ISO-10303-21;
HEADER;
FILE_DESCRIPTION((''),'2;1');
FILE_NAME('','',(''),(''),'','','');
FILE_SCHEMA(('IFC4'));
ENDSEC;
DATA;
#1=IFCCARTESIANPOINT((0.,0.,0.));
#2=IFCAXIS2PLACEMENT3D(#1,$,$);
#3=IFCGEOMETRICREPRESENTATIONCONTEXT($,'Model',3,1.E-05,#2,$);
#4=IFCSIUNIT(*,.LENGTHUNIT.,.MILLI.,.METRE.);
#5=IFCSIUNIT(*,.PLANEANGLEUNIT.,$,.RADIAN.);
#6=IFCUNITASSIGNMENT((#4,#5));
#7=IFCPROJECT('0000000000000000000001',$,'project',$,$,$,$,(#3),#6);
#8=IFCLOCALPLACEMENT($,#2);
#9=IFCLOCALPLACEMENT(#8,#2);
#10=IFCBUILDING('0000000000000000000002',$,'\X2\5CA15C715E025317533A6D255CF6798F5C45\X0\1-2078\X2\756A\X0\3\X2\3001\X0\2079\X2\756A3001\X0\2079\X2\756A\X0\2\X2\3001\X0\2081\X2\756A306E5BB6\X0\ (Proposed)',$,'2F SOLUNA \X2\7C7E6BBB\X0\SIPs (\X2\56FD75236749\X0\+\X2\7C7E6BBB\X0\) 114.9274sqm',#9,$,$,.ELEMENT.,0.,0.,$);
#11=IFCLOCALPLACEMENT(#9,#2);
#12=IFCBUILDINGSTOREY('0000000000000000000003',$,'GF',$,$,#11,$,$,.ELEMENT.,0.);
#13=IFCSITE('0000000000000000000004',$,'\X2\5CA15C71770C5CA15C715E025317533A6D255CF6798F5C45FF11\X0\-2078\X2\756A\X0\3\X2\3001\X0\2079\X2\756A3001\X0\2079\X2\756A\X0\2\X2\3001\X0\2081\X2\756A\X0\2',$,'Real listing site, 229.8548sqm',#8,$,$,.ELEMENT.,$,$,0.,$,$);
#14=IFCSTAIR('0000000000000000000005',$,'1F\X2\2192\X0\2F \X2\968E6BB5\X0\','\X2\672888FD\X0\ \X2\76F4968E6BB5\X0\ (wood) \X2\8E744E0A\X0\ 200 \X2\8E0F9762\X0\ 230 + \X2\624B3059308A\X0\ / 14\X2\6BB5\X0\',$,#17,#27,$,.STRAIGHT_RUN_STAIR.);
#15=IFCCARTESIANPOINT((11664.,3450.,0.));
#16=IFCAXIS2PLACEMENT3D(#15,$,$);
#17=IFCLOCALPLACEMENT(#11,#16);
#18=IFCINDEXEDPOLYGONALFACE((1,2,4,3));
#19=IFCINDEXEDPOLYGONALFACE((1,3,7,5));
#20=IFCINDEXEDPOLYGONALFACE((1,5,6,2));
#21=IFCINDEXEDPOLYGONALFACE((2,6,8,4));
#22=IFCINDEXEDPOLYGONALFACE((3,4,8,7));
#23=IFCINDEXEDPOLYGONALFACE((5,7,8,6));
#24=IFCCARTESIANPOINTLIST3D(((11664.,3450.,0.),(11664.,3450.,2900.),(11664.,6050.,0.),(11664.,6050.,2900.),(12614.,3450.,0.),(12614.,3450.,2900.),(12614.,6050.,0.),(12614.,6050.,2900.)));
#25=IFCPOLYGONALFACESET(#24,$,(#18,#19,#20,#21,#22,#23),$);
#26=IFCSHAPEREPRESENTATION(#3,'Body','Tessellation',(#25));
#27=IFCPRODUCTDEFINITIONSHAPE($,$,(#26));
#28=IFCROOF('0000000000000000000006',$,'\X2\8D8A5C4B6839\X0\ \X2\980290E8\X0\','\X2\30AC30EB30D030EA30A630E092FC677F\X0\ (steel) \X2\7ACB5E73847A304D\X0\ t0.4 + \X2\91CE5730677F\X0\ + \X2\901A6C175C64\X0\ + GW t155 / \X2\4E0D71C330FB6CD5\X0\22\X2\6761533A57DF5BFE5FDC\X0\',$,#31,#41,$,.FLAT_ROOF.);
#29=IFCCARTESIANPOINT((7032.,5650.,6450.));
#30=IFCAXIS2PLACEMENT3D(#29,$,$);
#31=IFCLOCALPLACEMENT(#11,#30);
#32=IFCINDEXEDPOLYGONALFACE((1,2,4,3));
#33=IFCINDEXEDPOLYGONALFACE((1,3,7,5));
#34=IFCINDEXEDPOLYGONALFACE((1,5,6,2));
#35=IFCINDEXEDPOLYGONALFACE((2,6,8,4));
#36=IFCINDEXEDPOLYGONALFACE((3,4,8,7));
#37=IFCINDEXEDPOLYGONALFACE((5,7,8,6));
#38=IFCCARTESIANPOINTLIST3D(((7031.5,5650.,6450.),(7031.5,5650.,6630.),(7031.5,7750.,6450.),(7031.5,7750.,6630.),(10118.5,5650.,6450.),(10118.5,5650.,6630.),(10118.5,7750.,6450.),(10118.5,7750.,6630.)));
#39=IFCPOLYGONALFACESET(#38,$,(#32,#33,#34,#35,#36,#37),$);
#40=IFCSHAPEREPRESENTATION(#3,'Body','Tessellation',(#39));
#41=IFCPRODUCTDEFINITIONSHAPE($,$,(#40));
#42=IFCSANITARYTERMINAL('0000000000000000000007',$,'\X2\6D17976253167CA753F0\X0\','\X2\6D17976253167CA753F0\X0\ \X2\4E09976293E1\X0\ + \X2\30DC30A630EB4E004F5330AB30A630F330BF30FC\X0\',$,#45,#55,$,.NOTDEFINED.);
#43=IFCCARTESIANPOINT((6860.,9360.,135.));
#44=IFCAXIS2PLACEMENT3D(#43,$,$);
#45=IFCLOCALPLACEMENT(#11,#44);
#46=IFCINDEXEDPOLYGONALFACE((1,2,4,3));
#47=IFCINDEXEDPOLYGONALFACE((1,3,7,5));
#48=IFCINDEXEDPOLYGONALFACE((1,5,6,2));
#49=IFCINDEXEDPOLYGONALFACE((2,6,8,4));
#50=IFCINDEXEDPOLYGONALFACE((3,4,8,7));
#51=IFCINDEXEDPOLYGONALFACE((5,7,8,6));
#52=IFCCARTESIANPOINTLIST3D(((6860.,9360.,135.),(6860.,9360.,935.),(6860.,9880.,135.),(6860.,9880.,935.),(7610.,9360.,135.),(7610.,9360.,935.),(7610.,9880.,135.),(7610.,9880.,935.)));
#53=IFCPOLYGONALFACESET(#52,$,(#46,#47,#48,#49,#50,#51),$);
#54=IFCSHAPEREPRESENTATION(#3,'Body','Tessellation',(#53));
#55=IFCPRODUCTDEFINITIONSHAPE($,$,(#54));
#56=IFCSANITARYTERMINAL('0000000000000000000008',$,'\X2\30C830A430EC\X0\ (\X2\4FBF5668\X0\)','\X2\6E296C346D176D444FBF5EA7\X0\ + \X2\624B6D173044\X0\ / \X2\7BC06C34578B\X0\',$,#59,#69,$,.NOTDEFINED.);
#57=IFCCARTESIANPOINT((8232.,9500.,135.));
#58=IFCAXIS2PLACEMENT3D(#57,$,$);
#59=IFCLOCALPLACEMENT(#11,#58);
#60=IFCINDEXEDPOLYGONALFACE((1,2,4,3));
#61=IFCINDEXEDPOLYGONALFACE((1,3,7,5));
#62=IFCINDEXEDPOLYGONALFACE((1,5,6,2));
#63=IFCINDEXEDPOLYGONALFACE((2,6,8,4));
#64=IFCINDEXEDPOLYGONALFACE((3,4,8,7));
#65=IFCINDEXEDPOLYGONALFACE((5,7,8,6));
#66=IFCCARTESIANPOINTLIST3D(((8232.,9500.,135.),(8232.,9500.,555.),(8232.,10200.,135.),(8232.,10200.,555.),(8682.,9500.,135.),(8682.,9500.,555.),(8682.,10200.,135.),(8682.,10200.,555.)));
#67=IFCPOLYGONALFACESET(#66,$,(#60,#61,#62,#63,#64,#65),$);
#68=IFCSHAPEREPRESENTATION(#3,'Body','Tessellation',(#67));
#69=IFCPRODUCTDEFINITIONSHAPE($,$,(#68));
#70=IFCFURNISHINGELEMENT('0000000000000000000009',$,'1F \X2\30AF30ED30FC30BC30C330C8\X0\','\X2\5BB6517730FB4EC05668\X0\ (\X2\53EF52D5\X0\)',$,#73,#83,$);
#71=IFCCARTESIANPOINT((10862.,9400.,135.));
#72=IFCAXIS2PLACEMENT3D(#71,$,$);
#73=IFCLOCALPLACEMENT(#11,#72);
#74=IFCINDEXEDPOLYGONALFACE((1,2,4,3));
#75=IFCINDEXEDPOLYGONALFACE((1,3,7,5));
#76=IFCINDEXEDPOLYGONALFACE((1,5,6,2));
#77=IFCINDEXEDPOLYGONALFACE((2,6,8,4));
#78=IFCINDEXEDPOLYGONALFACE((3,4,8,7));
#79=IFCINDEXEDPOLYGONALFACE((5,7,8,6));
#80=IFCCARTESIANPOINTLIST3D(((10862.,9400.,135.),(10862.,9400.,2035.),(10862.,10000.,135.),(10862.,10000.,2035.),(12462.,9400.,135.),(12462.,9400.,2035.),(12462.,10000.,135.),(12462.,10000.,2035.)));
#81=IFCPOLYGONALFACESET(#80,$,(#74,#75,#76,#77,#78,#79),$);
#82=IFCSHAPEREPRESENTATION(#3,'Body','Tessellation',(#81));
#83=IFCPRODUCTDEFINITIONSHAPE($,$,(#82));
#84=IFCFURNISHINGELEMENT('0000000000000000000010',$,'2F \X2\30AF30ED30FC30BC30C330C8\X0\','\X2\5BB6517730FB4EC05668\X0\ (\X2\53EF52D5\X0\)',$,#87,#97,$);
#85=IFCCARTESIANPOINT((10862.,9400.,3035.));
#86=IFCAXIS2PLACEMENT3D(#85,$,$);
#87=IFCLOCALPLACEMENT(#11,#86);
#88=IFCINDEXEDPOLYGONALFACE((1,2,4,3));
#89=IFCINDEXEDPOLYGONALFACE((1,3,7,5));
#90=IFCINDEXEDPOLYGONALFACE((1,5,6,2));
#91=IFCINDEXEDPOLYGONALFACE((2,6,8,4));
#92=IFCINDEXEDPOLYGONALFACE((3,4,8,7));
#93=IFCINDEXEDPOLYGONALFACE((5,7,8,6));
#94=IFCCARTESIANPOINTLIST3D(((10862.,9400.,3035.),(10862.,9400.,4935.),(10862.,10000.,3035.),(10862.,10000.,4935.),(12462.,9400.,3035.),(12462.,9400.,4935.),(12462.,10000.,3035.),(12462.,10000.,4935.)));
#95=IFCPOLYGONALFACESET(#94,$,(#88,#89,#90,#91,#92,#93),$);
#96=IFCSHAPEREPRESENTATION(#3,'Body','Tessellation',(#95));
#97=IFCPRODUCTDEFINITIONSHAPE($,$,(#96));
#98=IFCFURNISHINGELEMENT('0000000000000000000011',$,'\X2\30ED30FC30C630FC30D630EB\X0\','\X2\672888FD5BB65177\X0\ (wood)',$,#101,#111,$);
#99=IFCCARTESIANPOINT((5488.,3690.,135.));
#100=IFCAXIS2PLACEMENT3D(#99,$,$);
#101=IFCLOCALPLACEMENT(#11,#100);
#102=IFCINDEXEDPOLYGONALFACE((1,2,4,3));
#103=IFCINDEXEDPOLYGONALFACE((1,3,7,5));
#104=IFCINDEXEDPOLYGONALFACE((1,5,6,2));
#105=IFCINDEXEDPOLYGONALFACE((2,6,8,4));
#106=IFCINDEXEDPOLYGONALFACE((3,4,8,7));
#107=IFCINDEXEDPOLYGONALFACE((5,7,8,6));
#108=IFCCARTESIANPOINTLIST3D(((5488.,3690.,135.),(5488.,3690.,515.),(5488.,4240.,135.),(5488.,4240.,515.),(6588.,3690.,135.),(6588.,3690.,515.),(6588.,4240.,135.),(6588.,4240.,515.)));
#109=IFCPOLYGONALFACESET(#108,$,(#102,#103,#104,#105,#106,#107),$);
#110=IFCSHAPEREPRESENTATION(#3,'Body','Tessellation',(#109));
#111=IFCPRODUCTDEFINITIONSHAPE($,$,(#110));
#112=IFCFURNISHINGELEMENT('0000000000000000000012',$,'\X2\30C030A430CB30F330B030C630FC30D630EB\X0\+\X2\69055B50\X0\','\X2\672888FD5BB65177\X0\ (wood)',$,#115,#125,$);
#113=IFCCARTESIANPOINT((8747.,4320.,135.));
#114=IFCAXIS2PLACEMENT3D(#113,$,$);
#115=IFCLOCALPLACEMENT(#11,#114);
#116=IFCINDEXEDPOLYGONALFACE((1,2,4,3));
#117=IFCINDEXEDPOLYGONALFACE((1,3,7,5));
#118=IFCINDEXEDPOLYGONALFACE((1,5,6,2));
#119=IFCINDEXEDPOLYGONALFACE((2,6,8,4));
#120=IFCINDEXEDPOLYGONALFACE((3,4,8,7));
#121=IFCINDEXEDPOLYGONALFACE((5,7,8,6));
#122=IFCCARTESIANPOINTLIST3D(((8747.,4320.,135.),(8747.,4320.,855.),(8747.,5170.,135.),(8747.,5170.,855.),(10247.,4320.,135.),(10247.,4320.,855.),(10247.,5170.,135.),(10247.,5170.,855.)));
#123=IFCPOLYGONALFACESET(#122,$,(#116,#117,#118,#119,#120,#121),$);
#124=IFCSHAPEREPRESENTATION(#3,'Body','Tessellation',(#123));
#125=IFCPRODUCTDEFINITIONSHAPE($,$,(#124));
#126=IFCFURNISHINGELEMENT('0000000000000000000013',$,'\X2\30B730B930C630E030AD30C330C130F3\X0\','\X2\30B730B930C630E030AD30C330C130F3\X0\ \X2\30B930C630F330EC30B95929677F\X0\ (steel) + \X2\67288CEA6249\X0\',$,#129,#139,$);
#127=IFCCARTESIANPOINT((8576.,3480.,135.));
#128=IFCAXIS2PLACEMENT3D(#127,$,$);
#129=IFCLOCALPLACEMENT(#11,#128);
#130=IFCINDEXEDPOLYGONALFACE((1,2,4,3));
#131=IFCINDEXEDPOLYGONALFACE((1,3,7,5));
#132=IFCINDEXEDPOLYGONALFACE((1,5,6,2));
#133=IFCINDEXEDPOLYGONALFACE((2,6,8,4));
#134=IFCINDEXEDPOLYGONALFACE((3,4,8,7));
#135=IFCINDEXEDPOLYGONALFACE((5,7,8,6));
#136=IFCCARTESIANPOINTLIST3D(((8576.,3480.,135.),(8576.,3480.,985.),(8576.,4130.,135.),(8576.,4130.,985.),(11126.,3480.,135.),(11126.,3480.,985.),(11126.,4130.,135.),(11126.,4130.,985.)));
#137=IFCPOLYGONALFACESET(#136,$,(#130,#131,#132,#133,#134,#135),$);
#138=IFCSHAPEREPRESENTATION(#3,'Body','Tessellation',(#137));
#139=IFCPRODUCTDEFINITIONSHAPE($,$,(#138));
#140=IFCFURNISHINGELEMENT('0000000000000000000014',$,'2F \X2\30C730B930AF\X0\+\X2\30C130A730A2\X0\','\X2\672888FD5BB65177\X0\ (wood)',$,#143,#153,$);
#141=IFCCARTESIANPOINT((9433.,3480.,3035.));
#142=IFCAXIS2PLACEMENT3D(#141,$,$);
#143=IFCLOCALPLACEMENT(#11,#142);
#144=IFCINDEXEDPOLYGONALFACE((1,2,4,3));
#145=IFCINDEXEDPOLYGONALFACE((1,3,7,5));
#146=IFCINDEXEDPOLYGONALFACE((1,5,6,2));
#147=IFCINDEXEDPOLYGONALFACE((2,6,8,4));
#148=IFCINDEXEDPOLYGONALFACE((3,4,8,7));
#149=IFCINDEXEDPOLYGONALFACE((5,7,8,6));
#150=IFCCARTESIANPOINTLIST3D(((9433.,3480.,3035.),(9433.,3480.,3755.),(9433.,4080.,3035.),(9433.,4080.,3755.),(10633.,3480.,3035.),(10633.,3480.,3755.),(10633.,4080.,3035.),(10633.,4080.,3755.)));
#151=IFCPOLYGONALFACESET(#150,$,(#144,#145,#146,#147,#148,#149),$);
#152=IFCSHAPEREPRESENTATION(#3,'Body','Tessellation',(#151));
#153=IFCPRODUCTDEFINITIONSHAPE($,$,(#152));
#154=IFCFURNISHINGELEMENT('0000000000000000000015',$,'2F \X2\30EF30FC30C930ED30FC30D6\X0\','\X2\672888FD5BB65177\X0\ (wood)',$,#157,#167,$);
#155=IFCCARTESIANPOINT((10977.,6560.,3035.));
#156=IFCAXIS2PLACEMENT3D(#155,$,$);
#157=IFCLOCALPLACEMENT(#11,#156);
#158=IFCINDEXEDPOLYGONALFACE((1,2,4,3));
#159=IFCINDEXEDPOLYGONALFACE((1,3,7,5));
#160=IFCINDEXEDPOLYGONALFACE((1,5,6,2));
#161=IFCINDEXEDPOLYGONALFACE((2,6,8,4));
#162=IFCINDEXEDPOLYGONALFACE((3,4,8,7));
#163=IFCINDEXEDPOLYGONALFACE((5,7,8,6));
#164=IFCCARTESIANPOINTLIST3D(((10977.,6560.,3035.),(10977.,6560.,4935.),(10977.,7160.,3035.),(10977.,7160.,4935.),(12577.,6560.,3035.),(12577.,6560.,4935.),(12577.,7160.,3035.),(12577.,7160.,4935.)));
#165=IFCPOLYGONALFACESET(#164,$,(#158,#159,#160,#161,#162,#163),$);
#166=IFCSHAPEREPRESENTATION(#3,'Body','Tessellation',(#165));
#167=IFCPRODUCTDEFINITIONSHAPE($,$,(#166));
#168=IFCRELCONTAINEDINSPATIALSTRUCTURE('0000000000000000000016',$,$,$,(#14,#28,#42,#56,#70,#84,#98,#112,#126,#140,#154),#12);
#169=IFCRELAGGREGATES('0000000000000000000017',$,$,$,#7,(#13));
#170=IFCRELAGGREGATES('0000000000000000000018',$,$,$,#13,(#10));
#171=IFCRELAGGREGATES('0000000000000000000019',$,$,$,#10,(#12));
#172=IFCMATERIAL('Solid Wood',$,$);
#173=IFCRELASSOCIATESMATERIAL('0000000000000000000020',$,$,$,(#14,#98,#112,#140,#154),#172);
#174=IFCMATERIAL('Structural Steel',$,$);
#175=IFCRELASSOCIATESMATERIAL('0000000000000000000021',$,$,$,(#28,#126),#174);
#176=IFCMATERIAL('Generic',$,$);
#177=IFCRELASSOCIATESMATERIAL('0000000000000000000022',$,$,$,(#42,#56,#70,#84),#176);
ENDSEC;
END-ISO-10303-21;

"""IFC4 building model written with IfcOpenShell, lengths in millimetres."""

from ifc_helpers import new_model, si_unit, frame, frame_2d, origin, place, context, project, spatial, rectangle, extrude, material, element, save


model = new_model("IFC4")

# Units and contexts
model_context = context("Model", 3, precision=1e-05, world=origin())
ifc_project = project(units=[si_unit("LENGTHUNIT", "METRE", prefix="MILLI"), si_unit("PLANEANGLEUNIT", "RADIAN")], contexts=[model_context])

# Site, building, storey
site_placement = place(None, origin())
site = spatial("IfcSite", under=ifc_project, at=site_placement, Name="岡山県岡山市北区津島福居１-2078番3、2079番、2079番2、2081番2", ObjectType="Real listing site, 229.8548sqm", CompositionType="ELEMENT", RefElevation=0.0)
building_placement = place(site_placement, origin())
building = spatial("IfcBuilding", under=site, at=building_placement, Name="岡山市北区津島福居1-2078番3、2079番、2079番2、2081番の家 (Proposed)", ObjectType="2F SOLUNA 籾殻SIPs (国産杉+籾殻) 114.9274sqm", CompositionType="ELEMENT", ElevationOfRefHeight=0.0, ElevationOfTerrain=0.0)
storey_placement = place(building_placement, origin())
storey = spatial("IfcBuildingStorey", under=building, at=storey_placement, Name="GF", CompositionType="ELEMENT", Elevation=0.0)

# Shared definitions
ifc_material_1 = material(Name="Solid Wood")

# Stair
stair_placement = place(storey_placement, frame((11664.0, 3450.0, 0.0)))
element("IfcStair", 1, at=stair_placement, inside=storey, material=ifc_material_1, Name="1F→2F 階段", Description="木製 直階段 (wood) 蹴上 200 踏面 230 + 手すり / 14段", PredefinedType="STRAIGHT_RUN_STAIR", context=model_context, shape_type="SweptSolid", body=[
    extrude(rectangle(XDim=950.0, YDim=2600.0, at=frame_2d((475.0, 1300.0))), frame((11664.0, 3450.0, 0.0)), (0.0, 0.0, 1.0), 2900.0),
])

# Roof
ifc_material_2 = material(Name="Structural Steel")
roof_placement = place(storey_placement, frame((7032.0, 5650.0, 6450.0)))
element("IfcRoof", 2, at=roof_placement, inside=storey, material=ifc_material_2, Name="越屋根 頂部", Description="ガルバリウム鋼板 (steel) 立平葺き t0.4 + 野地板 + 通気層 + GW t155 / 不燃・法22条区域対応", PredefinedType="FLAT_ROOF", context=model_context, shape_type="SweptSolid", body=[
    extrude(rectangle(XDim=3087.0, YDim=2100.0, at=frame_2d((1543.0, 1050.0))), frame((7032.0, 5650.0, 6450.0)), (0.0, 0.0, 1.0), 180.0),
])

# Sanitary terminals
ifc_material_3 = material(Name="Generic")
sanitary_terminal_1_placement = place(storey_placement, frame((6860.0, 9360.0, 135.0)))
element("IfcSanitaryTerminal", 3, at=sanitary_terminal_1_placement, inside=storey, material=ifc_material_3, Name="洗面化粧台", Description="洗面化粧台 三面鏡 + ボウル一体カウンター", PredefinedType="NOTDEFINED", context=model_context, shape_type="SweptSolid", body=[
    extrude(rectangle(XDim=750.0, YDim=520.0, at=frame_2d((375.0, 260.0))), frame((6860.0, 9360.0, 135.0)), (0.0, 0.0, 1.0), 800.0),
])
sanitary_terminal_2_placement = place(storey_placement, frame((8232.0, 9500.0, 135.0)))
element("IfcSanitaryTerminal", 4, at=sanitary_terminal_2_placement, inside=storey, material=ifc_material_3, Name="トイレ (便器)", Description="温水洗浄便座 + 手洗い / 節水型", PredefinedType="NOTDEFINED", context=model_context, shape_type="SweptSolid", body=[
    extrude(rectangle(XDim=450.0, YDim=700.0, at=frame_2d((225.0, 350.0))), frame((8232.0, 9500.0, 135.0)), (0.0, 0.0, 1.0), 420.0),
])

# Furnishing elements
furnishing_1_placement = place(storey_placement, frame((10862.0, 9400.0, 135.0)))
element("IfcFurnishingElement", 5, at=furnishing_1_placement, inside=storey, material=ifc_material_3, Name="1F クローゼット", Description="家具・什器 (可動)", context=model_context, shape_type="SweptSolid", body=[
    extrude(rectangle(XDim=1600.0, YDim=600.0, at=frame_2d((800.0, 300.0))), frame((10862.0, 9400.0, 135.0)), (0.0, 0.0, 1.0), 1900.0),
])
furnishing_2_placement = place(storey_placement, frame((10862.0, 9400.0, 3035.0)))
element("IfcFurnishingElement", 6, at=furnishing_2_placement, inside=storey, material=ifc_material_3, Name="2F クローゼット", Description="家具・什器 (可動)", context=model_context, shape_type="SweptSolid", body=[
    extrude(rectangle(XDim=1600.0, YDim=600.0, at=frame_2d((800.0, 300.0))), frame((10862.0, 9400.0, 3035.0)), (0.0, 0.0, 1.0), 1900.0),
])
furnishing_3_placement = place(storey_placement, frame((5488.0, 3690.0, 135.0)))
element("IfcFurnishingElement", 7, at=furnishing_3_placement, inside=storey, material=ifc_material_1, Name="ローテーブル", Description="木製家具 (wood)", context=model_context, shape_type="SweptSolid", body=[
    extrude(rectangle(XDim=1100.0, YDim=550.0, at=frame_2d((550.0, 275.0))), frame((5488.0, 3690.0, 135.0)), (0.0, 0.0, 1.0), 380.0),
])
furnishing_4_placement = place(storey_placement, frame((8747.0, 4320.0, 135.0)))
element("IfcFurnishingElement", 8, at=furnishing_4_placement, inside=storey, material=ifc_material_1, Name="ダイニングテーブル+椅子", Description="木製家具 (wood)", context=model_context, shape_type="SweptSolid", body=[
    extrude(rectangle(XDim=1500.0, YDim=850.0, at=frame_2d((750.0, 425.0))), frame((8747.0, 4320.0, 135.0)), (0.0, 0.0, 1.0), 720.0),
])
furnishing_5_placement = place(storey_placement, frame((8576.0, 3480.0, 135.0)))
element("IfcFurnishingElement", 9, at=furnishing_5_placement, inside=storey, material=ifc_material_2, Name="システムキッチン", Description="システムキッチン ステンレス天板 (steel) + 木質扉", context=model_context, shape_type="SweptSolid", body=[
    extrude(rectangle(XDim=2550.0, YDim=650.0, at=frame_2d((1275.0, 325.0))), frame((8576.0, 3480.0, 135.0)), (0.0, 0.0, 1.0), 850.0),
])
furnishing_6_placement = place(storey_placement, frame((9433.0, 3480.0, 3035.0)))
element("IfcFurnishingElement", 10, at=furnishing_6_placement, inside=storey, material=ifc_material_1, Name="2F デスク+チェア", Description="木製家具 (wood)", context=model_context, shape_type="SweptSolid", body=[
    extrude(rectangle(XDim=1200.0, YDim=600.0, at=frame_2d((600.0, 300.0))), frame((9433.0, 3480.0, 3035.0)), (0.0, 0.0, 1.0), 720.0),
])
furnishing_7_placement = place(storey_placement, frame((10977.0, 6560.0, 3035.0)))
element("IfcFurnishingElement", 11, at=furnishing_7_placement, inside=storey, material=ifc_material_1, Name="2F ワードローブ", Description="木製家具 (wood)", context=model_context, shape_type="SweptSolid", body=[
    extrude(rectangle(XDim=1600.0, YDim=600.0, at=frame_2d((800.0, 300.0))), frame((10977.0, 6560.0, 3035.0)), (0.0, 0.0, 1.0), 1900.0),
])

save(model, "model.ifc")
